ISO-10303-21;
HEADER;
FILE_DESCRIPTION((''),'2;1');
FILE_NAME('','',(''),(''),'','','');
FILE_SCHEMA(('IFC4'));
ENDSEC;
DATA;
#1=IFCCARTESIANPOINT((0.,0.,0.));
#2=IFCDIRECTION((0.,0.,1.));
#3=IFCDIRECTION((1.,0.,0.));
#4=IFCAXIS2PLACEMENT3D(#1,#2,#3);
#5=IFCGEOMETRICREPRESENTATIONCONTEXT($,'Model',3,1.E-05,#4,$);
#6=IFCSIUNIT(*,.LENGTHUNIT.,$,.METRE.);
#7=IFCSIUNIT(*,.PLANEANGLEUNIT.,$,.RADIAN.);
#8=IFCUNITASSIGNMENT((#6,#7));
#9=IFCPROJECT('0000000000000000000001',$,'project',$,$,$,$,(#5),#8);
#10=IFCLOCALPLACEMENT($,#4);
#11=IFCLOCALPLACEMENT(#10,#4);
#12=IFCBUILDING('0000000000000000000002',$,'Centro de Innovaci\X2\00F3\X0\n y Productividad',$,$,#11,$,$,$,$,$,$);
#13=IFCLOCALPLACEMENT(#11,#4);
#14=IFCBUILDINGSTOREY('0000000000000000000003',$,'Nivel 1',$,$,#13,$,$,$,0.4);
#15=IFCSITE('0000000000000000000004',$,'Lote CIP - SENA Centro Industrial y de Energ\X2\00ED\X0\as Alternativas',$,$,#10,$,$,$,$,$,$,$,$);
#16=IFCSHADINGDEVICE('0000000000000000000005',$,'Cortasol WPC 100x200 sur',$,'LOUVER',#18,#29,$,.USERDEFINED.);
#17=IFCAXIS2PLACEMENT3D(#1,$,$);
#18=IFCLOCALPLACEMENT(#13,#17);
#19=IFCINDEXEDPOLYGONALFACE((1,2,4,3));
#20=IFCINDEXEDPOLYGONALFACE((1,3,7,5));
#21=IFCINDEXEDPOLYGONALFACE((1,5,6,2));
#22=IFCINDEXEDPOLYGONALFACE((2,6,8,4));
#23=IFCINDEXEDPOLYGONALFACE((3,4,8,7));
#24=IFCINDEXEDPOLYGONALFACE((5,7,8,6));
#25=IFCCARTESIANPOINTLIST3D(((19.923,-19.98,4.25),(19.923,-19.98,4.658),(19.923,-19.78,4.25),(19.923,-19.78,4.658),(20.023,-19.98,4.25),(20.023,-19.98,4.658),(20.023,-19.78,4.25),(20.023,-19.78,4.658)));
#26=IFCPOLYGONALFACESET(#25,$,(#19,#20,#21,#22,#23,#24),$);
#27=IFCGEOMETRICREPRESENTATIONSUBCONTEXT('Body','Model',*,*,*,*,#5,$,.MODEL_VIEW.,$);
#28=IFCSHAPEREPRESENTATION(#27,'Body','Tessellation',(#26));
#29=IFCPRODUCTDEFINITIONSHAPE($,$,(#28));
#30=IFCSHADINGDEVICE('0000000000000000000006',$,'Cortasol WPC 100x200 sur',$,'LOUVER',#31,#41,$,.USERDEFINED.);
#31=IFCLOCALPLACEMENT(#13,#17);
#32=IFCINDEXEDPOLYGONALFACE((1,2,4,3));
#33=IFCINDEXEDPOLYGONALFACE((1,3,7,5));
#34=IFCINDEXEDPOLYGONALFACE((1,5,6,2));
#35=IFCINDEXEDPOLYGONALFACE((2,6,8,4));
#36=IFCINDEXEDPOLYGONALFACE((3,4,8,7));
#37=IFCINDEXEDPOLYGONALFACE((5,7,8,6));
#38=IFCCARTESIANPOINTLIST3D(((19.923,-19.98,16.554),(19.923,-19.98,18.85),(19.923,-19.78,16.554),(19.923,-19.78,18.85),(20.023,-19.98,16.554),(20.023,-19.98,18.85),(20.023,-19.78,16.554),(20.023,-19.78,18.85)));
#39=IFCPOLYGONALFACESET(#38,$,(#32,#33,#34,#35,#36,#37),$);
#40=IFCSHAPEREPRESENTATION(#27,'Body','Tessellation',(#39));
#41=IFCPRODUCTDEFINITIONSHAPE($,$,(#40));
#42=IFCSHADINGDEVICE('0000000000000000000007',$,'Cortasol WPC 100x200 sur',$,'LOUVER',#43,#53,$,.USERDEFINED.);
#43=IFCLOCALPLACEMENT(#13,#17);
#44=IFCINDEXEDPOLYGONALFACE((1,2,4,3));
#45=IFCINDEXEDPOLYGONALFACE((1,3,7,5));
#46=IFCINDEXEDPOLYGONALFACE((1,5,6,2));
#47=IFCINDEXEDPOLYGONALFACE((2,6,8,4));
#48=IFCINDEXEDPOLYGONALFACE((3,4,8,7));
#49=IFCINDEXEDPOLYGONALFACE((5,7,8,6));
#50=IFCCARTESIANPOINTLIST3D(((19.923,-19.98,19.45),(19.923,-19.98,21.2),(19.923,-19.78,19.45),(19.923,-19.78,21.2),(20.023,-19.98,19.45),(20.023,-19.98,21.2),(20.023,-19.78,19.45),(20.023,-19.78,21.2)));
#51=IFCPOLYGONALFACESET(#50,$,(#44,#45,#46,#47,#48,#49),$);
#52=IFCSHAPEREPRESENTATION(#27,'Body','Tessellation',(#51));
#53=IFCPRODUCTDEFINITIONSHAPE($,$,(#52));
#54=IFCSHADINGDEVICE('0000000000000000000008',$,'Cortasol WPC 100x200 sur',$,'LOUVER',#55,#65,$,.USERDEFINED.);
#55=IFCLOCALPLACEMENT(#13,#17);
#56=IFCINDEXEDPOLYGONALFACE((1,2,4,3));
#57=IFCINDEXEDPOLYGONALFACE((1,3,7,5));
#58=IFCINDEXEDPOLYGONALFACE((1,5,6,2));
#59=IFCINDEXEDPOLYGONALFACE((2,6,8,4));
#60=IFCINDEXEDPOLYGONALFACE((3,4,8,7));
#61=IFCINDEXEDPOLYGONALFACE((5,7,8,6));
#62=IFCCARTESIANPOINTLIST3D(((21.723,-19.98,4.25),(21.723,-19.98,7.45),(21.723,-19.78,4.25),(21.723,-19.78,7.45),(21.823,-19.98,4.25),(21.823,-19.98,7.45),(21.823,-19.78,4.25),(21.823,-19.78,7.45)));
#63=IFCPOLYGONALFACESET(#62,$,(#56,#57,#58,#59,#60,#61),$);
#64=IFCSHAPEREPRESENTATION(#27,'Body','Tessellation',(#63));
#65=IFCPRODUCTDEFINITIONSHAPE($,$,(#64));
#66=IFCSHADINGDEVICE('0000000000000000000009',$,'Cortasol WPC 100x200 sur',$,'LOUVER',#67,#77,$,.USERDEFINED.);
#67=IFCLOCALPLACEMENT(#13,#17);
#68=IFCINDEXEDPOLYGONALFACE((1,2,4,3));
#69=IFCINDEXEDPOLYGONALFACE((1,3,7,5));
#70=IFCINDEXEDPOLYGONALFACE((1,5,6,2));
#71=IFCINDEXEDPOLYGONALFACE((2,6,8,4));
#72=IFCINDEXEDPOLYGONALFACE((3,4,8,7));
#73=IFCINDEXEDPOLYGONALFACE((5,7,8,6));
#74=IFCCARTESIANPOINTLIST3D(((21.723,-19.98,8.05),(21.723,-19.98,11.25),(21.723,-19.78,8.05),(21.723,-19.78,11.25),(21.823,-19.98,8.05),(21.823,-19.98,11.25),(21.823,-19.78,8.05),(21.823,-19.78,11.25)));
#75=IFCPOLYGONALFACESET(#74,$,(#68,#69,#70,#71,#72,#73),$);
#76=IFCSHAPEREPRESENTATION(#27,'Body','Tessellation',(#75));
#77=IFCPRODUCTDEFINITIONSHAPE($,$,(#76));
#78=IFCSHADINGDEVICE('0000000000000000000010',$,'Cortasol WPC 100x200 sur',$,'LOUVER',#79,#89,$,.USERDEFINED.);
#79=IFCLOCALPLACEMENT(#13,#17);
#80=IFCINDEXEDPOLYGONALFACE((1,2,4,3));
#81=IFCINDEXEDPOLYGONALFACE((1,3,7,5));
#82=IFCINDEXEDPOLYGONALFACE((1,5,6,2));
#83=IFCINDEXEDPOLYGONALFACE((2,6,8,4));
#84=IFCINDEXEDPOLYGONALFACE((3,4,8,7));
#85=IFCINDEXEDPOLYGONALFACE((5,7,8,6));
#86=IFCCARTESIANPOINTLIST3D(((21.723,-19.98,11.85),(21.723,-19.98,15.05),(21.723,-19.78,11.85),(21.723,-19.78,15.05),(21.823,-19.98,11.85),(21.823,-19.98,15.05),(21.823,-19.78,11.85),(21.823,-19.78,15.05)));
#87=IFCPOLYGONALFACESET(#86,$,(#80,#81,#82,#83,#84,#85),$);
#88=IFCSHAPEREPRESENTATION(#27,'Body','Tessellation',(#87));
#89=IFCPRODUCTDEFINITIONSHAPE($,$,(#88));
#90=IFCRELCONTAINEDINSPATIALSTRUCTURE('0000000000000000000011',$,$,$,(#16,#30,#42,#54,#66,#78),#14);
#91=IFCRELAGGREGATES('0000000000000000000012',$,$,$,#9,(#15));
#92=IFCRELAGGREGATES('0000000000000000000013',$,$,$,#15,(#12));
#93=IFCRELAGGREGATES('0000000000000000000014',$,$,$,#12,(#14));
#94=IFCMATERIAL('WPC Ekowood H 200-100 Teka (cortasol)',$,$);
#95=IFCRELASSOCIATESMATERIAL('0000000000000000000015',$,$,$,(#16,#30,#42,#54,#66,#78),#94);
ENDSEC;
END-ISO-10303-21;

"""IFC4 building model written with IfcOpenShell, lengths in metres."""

from ifc_helpers import new_model, si_unit, frame, origin_with_axes, place, context, subcontext, project, spatial, polyline, outline, extrude, material, element, save


model = new_model("IFC4")

# Units and contexts
model_context = context("Model", 3, precision=1e-05, world=origin_with_axes())
body_context = subcontext(model_context, "Body", "Model", "MODEL_VIEW")
ifc_project = project(units=[si_unit("LENGTHUNIT", "METRE"), si_unit("PLANEANGLEUNIT", "RADIAN")], contexts=[model_context])

# Site, building, storey
site_placement = place(None, origin_with_axes())
site = spatial("IfcSite", under=ifc_project, at=site_placement, Name="Lote CIP - SENA Centro Industrial y de Energías Alternativas")
building_placement = place(site_placement, origin_with_axes())
building = spatial("IfcBuilding", under=site, at=building_placement, Name="Centro de Innovación y Productividad")
storey_placement = place(building_placement, origin_with_axes())
storey = spatial("IfcBuildingStorey", under=building, at=storey_placement, Name="Nivel 1", Elevation=0.4)

# Shading devices
ifc_material_1 = material(Name="WPC Ekowood H 200-100 Teka (cortasol)")
shading_device_1_placement = place(storey_placement, origin_with_axes())
element("IfcShadingDevice", 1, at=shading_device_1_placement, inside=storey, material=ifc_material_1, Name="Cortasol WPC 100x200 sur", ObjectType="LOUVER", PredefinedType="USERDEFINED", context=body_context, shape_type="SweptSolid", body=[
    extrude(outline(polyline([(19.923, -19.98), (19.923, -19.78), (20.023, -19.78), (20.023, -19.98), (19.923, -19.98)])), frame((0.0, 0.0, 4.25)), (0.0, 0.0, 1.0), 0.408),
])
shading_device_2_placement = place(storey_placement, origin_with_axes())
element("IfcShadingDevice", 2, at=shading_device_2_placement, inside=storey, material=ifc_material_1, Name="Cortasol WPC 100x200 sur", ObjectType="LOUVER", PredefinedType="USERDEFINED", context=body_context, shape_type="SweptSolid", body=[
    extrude(outline(polyline([(19.923, -19.98), (19.923, -19.78), (20.023, -19.78), (20.023, -19.98), (19.923, -19.98)])), frame((0.0, 0.0, 16.554)), (0.0, 0.0, 1.0), 2.296),
])
shading_device_3_placement = place(storey_placement, origin_with_axes())
element("IfcShadingDevice", 3, at=shading_device_3_placement, inside=storey, material=ifc_material_1, Name="Cortasol WPC 100x200 sur", ObjectType="LOUVER", PredefinedType="USERDEFINED", context=body_context, shape_type="SweptSolid", body=[
    extrude(outline(polyline([(19.923, -19.98), (19.923, -19.78), (20.023, -19.78), (20.023, -19.98), (19.923, -19.98)])), frame((0.0, 0.0, 19.45)), (0.0, 0.0, 1.0), 1.75),
])
shading_device_4_placement = place(storey_placement, origin_with_axes())
element("IfcShadingDevice", 4, at=shading_device_4_placement, inside=storey, material=ifc_material_1, Name="Cortasol WPC 100x200 sur", ObjectType="LOUVER", PredefinedType="USERDEFINED", context=body_context, shape_type="SweptSolid", body=[
    extrude(outline(polyline([(21.723, -19.98), (21.723, -19.78), (21.823, -19.78), (21.823, -19.98), (21.723, -19.98)])), frame((0.0, 0.0, 4.25)), (0.0, 0.0, 1.0), 3.2),
])
shading_device_5_placement = place(storey_placement, origin_with_axes())
element("IfcShadingDevice", 5, at=shading_device_5_placement, inside=storey, material=ifc_material_1, Name="Cortasol WPC 100x200 sur", ObjectType="LOUVER", PredefinedType="USERDEFINED", context=body_context, shape_type="SweptSolid", body=[
    extrude(outline(polyline([(21.723, -19.98), (21.723, -19.78), (21.823, -19.78), (21.823, -19.98), (21.723, -19.98)])), frame((0.0, 0.0, 8.05)), (0.0, 0.0, 1.0), 3.2),
])
shading_device_6_placement = place(storey_placement, origin_with_axes())
element("IfcShadingDevice", 6, at=shading_device_6_placement, inside=storey, material=ifc_material_1, Name="Cortasol WPC 100x200 sur", ObjectType="LOUVER", PredefinedType="USERDEFINED", context=body_context, shape_type="SweptSolid", body=[
    extrude(outline(polyline([(21.723, -19.98), (21.723, -19.78), (21.823, -19.78), (21.823, -19.98), (21.723, -19.98)])), frame((0.0, 0.0, 11.85)), (0.0, 0.0, 1.0), 3.2),
])

save(model, "model.ifc")
